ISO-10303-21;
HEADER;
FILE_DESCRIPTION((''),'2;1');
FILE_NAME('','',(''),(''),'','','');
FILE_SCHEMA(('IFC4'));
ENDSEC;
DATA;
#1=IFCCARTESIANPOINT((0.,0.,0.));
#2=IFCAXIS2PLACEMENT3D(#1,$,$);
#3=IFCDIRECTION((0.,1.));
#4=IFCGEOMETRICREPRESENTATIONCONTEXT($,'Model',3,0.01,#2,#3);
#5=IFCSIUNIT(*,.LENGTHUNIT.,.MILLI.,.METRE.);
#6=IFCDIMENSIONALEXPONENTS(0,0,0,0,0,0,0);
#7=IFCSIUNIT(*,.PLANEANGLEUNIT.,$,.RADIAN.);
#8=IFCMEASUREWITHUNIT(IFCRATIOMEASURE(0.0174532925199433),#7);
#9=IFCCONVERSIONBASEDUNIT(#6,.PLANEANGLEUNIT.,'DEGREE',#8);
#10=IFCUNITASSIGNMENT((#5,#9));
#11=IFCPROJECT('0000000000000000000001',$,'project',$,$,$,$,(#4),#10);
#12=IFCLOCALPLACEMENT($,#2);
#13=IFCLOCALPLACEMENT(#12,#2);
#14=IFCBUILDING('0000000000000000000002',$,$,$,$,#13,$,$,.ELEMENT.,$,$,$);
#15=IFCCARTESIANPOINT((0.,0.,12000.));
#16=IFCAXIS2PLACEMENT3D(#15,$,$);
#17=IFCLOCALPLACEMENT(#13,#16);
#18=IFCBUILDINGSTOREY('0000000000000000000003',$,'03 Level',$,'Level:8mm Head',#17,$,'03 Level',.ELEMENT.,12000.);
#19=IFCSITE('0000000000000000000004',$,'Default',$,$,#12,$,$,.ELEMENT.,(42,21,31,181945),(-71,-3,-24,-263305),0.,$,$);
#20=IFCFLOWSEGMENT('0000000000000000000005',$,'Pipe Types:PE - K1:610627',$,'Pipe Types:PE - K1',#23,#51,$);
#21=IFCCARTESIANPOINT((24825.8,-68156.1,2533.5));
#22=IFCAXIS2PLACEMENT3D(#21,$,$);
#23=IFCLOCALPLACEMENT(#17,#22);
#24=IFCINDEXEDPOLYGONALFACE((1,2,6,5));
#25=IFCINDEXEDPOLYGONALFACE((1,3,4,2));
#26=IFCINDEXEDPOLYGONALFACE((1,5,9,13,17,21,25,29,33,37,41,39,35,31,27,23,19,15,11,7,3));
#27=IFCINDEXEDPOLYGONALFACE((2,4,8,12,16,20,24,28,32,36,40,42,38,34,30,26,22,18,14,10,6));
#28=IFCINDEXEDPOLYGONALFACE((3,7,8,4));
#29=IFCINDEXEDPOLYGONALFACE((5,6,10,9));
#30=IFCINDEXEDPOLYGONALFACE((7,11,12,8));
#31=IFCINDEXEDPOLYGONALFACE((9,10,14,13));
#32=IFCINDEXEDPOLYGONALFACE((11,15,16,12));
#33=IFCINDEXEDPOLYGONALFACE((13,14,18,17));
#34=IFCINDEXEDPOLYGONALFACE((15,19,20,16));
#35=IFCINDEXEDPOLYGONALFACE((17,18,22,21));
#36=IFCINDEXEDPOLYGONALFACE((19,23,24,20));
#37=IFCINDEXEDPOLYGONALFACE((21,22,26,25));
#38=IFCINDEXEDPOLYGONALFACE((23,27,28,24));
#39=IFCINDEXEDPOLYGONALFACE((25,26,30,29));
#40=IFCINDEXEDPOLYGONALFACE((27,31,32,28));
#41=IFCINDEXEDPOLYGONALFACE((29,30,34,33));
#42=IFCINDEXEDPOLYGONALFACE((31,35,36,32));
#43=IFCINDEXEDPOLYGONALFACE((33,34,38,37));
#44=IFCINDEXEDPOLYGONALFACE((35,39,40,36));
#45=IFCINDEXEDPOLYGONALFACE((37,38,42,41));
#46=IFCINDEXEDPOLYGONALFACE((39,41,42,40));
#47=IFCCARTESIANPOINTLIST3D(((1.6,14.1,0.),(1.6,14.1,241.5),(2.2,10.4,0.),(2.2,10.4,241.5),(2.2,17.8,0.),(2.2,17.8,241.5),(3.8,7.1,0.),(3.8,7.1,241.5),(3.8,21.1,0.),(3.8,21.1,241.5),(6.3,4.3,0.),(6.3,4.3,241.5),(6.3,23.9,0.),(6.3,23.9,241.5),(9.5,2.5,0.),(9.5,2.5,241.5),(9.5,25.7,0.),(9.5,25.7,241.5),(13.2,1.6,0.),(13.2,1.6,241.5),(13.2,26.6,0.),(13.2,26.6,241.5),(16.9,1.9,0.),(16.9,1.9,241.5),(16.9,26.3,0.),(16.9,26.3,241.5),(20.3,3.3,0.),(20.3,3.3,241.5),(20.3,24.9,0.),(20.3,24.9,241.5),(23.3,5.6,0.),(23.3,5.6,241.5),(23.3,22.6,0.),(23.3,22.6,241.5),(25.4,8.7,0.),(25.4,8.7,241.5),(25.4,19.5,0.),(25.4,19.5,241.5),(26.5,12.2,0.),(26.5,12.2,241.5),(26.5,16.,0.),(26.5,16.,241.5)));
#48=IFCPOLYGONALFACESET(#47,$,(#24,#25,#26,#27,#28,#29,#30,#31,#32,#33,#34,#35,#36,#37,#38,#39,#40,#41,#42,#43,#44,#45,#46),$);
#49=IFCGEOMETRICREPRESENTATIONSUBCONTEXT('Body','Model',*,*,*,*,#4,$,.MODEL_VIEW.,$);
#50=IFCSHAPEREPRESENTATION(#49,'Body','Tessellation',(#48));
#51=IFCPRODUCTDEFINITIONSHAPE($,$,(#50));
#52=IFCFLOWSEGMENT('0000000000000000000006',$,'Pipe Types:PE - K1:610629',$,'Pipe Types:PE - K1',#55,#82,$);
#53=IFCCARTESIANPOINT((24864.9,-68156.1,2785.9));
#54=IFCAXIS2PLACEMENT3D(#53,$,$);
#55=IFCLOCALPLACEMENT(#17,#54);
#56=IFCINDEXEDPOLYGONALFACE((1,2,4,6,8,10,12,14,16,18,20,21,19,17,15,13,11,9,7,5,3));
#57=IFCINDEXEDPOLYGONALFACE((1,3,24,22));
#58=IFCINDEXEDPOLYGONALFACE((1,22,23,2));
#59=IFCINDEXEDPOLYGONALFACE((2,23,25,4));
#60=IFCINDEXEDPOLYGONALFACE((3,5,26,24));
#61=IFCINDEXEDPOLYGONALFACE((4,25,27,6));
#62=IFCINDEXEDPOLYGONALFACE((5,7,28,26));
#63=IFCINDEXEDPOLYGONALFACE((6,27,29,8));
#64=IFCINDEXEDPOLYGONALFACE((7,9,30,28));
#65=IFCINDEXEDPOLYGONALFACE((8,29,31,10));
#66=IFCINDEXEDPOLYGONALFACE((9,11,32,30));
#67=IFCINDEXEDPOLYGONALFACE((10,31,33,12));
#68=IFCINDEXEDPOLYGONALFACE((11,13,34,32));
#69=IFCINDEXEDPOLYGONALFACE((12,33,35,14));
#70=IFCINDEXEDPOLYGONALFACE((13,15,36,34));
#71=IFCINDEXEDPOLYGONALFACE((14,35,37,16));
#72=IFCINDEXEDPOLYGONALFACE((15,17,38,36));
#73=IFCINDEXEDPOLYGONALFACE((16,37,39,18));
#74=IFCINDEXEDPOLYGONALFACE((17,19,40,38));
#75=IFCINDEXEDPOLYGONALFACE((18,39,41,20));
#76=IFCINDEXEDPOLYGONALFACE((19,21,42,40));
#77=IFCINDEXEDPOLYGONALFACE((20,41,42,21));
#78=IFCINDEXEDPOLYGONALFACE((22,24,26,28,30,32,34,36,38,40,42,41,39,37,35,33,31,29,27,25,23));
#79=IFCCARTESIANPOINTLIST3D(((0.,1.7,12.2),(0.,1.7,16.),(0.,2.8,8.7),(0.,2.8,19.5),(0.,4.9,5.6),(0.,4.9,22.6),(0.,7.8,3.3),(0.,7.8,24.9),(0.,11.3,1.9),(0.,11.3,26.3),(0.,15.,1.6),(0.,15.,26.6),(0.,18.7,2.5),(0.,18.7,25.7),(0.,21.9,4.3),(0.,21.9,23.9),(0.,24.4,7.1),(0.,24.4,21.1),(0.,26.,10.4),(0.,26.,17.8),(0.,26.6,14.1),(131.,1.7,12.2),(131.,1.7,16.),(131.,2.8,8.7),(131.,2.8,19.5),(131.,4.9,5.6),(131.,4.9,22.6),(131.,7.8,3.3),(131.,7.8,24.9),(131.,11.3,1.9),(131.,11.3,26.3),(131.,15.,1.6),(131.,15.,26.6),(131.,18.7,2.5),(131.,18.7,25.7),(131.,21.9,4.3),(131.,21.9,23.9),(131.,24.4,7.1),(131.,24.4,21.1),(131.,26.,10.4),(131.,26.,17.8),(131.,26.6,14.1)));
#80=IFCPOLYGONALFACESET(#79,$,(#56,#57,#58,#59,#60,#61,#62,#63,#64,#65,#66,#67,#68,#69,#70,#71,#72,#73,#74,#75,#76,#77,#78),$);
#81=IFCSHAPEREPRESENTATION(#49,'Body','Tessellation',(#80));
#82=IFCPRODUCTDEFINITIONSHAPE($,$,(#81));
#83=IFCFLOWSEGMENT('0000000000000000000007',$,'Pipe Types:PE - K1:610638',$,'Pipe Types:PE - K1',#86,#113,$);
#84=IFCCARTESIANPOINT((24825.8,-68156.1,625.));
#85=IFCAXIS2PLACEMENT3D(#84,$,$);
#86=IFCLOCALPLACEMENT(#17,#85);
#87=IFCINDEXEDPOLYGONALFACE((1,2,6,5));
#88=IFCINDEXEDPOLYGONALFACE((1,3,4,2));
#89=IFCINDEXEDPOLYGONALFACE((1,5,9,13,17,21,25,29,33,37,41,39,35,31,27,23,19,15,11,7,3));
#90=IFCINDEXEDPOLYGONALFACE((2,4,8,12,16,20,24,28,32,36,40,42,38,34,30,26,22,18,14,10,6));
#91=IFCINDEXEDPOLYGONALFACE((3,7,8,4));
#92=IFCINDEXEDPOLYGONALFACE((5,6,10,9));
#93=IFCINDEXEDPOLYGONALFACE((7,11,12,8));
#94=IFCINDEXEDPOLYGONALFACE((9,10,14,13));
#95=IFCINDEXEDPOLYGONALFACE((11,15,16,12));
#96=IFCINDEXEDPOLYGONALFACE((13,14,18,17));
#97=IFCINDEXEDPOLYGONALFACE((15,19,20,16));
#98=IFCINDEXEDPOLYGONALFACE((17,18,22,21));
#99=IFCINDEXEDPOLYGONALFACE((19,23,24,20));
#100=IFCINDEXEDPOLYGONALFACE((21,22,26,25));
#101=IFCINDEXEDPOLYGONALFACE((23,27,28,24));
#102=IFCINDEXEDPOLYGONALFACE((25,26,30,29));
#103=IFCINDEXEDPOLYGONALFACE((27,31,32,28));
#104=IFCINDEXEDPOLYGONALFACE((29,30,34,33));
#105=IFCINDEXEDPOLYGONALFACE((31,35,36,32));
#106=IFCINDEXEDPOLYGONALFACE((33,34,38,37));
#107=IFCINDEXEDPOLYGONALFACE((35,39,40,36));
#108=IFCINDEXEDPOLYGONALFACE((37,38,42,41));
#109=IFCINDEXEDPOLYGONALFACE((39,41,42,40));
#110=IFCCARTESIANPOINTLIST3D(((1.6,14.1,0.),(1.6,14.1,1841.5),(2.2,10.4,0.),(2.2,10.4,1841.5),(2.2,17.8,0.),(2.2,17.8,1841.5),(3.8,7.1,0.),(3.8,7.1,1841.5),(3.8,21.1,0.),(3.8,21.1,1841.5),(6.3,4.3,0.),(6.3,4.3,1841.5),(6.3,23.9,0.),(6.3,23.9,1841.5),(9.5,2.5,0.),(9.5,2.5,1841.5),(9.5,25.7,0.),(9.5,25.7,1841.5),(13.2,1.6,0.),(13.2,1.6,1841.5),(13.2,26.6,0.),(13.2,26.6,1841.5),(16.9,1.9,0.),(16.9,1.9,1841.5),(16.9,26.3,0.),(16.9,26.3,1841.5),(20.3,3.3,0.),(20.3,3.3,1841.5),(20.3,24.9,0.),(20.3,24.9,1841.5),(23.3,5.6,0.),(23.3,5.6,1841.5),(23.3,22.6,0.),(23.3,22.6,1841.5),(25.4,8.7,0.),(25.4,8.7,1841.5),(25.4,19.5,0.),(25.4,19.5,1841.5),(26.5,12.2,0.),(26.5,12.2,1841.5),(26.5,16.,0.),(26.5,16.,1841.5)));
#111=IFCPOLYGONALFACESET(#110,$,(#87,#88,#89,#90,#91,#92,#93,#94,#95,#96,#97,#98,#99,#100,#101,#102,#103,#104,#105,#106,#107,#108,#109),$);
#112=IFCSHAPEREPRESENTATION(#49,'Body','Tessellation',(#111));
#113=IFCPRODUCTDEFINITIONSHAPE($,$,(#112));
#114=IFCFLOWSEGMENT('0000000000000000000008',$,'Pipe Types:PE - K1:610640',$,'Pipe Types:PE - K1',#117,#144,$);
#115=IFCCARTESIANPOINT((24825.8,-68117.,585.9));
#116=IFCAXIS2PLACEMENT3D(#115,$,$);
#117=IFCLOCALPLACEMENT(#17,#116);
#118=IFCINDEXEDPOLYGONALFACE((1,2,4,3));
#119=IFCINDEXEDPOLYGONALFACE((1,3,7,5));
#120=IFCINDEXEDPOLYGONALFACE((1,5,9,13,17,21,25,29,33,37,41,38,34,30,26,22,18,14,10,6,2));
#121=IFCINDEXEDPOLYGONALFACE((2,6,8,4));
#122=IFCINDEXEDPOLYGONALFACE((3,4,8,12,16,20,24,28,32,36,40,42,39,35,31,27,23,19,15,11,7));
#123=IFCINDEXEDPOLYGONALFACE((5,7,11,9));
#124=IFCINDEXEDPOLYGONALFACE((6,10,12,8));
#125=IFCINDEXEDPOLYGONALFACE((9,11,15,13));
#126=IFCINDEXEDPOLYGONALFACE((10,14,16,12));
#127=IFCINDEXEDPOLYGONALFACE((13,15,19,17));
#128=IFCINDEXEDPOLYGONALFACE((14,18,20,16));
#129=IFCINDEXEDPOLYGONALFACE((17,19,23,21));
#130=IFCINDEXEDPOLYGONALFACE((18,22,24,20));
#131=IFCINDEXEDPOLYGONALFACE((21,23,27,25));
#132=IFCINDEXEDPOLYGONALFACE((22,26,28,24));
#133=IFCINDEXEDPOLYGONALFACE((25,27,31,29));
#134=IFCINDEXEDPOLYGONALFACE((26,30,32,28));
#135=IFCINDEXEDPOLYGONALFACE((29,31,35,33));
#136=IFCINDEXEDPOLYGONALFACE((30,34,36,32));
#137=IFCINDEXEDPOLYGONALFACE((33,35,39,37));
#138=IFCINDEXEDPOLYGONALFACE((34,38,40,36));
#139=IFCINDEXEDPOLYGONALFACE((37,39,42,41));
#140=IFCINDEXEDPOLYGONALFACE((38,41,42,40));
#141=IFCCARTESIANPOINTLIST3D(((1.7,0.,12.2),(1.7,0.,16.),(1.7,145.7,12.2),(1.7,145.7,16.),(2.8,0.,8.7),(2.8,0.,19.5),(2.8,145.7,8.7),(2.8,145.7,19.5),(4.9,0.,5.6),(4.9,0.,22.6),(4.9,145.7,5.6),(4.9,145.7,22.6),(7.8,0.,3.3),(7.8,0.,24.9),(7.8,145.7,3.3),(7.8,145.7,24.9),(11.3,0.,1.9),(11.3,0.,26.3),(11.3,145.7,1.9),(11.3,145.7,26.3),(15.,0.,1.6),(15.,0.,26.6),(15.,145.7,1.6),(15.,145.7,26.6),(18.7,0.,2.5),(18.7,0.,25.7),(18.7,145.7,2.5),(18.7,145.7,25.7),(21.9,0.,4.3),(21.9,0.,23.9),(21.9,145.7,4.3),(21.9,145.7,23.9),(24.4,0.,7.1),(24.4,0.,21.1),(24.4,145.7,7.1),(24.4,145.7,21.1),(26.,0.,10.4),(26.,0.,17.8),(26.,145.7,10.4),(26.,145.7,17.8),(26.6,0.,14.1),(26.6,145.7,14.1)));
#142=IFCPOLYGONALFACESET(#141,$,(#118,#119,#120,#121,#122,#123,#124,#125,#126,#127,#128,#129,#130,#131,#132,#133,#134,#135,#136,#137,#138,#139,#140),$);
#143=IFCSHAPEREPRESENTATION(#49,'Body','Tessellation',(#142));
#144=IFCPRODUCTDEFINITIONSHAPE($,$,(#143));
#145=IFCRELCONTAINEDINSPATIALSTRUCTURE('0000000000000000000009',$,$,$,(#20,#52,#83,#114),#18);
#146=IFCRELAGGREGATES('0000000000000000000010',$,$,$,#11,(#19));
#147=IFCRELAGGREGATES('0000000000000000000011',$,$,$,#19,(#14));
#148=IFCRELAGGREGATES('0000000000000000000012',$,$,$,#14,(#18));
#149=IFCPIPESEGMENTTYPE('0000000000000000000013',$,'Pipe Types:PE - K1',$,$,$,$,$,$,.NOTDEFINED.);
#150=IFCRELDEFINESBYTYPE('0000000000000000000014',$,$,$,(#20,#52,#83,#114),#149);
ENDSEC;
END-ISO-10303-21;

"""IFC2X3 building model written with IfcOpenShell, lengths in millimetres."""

from ifc_helpers import new_model, entity, si_unit, converted_unit, direction, frame, origin, origin_2d_with_axis, place, context, subcontext, project, spatial, circle, extrude, type_object, element, save


model = new_model("IFC2X3")

# Units and contexts
model_context = context("Model", 3, precision=0.01, world=origin(), true_north=direction((0.0, 1.0)))
body_context = subcontext(model_context, "Body", "Model", "MODEL_VIEW")
ifc_project = project(units=[si_unit("LENGTHUNIT", "METRE", prefix="MILLI"), converted_unit("PLANEANGLEUNIT", "DEGREE", entity("IfcRatioMeasure", 0.0174532925199433), si_unit("PLANEANGLEUNIT", "RADIAN"), dimensions=[0, 0, 0, 0, 0, 0, 0])], contexts=[model_context])

# Site, building, storey
site_placement = place(None, origin())
site = spatial("IfcSite", under=ifc_project, at=site_placement, Name="Default", CompositionType="ELEMENT", RefLatitude=(42, 21, 31, 181945), RefLongitude=(-71, -3, -24, -263305), RefElevation=0.0)
building_placement = place(site_placement, origin())
building = spatial("IfcBuilding", under=site, at=building_placement, CompositionType="ELEMENT")
storey_placement = place(building_placement, frame((0.0, 0.0, 12000.0)))
storey = spatial("IfcBuildingStorey", under=building, at=storey_placement, Name="03 Level", ObjectType="Level:8mm Head", LongName="03 Level", CompositionType="ELEMENT", Elevation=12000.0)

# Flow segments
pipe_segment_type = type_object("IfcPipeSegmentType", Name="Pipe Types:PE - K1", PredefinedType="NOTDEFINED")
flow_segment_1_placement = place(storey_placement, frame((24825.8, -68156.1, 2533.5)))
element("IfcFlowSegment", 1, at=flow_segment_1_placement, inside=storey, type_object=pipe_segment_type, Name="Pipe Types:PE - K1:610627", ObjectType="Pipe Types:PE - K1", context=body_context, shape_type="SweptSolid", body=[
    extrude(circle(Radius=12.5, at=origin_2d_with_axis()), frame((14.1, 14.1, 0.0), z_axis=(0.0, 0.0, 1.0), x_axis=(-1.0, 0.0, 0.0)), (0.0, 0.0, 1.0), 241.5),
])
flow_segment_2_placement = place(storey_placement, frame((24864.9, -68156.1, 2785.9)))
element("IfcFlowSegment", 2, at=flow_segment_2_placement, inside=storey, type_object=pipe_segment_type, Name="Pipe Types:PE - K1:610629", ObjectType="Pipe Types:PE - K1", context=body_context, shape_type="SweptSolid", body=[
    extrude(circle(Radius=12.5, at=origin_2d_with_axis()), frame((0.0, 14.1, 14.1), z_axis=(1.0, 0.0, 0.0), x_axis=(0.0, 1.0, 0.0)), (0.0, 0.0, 1.0), 131.0),
])
flow_segment_3_placement = place(storey_placement, frame((24825.8, -68156.1, 625.0)))
element("IfcFlowSegment", 3, at=flow_segment_3_placement, inside=storey, type_object=pipe_segment_type, Name="Pipe Types:PE - K1:610638", ObjectType="Pipe Types:PE - K1", context=body_context, shape_type="SweptSolid", body=[
    extrude(circle(Radius=12.5, at=origin_2d_with_axis()), frame((14.1, 14.1, 0.0), z_axis=(0.0, 0.0, 1.0), x_axis=(-1.0, 0.0, 0.0)), (0.0, 0.0, 1.0), 1841.5),
])
flow_segment_4_placement = place(storey_placement, frame((24825.8, -68117.0, 585.9)))
element("IfcFlowSegment", 4, at=flow_segment_4_placement, inside=storey, type_object=pipe_segment_type, Name="Pipe Types:PE - K1:610640", ObjectType="Pipe Types:PE - K1", context=body_context, shape_type="SweptSolid", body=[
    extrude(circle(Radius=12.5, at=origin_2d_with_axis()), frame((14.1, 0.0, 14.1), z_axis=(0.0, 1.0, 0.0), x_axis=(1.0, 0.0, 0.0)), (0.0, 0.0, 1.0), 145.7),
])

save(model, "model.ifc")
